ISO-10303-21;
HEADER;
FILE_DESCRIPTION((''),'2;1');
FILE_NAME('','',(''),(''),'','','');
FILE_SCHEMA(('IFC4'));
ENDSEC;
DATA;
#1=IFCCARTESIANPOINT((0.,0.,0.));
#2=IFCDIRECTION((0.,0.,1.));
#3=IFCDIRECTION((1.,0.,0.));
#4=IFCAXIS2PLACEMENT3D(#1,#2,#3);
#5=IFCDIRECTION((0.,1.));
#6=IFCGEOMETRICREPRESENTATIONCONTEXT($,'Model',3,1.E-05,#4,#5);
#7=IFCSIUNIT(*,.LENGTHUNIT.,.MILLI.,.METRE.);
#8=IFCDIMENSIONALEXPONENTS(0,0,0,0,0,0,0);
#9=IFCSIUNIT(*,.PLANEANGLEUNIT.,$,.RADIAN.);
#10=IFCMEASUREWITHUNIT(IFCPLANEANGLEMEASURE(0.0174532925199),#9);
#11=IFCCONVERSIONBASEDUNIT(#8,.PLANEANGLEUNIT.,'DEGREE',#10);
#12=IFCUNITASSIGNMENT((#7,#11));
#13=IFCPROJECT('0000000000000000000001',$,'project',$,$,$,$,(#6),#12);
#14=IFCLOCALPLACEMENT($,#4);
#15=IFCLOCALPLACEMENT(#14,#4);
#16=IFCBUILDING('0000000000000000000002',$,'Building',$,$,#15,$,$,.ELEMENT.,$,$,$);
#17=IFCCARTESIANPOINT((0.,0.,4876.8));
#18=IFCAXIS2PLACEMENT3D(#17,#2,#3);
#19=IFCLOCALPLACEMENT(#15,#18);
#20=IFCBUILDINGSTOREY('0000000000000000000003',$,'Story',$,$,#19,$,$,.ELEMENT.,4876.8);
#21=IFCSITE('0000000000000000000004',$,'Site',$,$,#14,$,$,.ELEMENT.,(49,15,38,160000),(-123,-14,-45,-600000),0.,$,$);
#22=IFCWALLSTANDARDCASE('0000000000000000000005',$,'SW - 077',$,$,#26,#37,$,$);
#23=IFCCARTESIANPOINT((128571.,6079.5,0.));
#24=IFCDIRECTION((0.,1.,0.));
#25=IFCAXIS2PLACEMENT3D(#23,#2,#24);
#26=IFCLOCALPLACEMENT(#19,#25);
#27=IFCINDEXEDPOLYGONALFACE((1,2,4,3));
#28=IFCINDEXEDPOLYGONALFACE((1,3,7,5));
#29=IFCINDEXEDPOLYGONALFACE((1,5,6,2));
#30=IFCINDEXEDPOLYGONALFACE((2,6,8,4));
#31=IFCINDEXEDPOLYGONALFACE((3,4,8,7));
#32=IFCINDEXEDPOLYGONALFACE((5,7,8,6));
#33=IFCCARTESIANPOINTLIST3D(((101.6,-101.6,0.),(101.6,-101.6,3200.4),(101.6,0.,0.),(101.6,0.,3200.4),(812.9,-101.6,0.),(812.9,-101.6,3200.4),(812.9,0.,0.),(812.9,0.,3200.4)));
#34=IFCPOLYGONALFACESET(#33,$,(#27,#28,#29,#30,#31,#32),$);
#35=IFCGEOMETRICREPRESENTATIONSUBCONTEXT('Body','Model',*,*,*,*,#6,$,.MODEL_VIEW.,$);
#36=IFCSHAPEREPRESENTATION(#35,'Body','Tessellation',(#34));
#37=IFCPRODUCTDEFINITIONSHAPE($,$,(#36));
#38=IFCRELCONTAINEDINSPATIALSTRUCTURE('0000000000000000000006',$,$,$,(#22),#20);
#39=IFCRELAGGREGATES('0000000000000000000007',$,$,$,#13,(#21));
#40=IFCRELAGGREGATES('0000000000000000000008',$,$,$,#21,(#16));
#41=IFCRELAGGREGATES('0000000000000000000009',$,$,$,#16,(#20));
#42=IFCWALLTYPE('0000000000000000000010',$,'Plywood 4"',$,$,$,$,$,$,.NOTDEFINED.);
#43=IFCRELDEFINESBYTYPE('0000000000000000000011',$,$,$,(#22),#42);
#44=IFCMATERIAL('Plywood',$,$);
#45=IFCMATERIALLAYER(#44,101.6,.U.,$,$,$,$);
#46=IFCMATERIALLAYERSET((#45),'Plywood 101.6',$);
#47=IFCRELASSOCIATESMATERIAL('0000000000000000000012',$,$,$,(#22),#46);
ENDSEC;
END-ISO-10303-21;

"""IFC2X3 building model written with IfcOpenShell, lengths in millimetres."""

from ifc_helpers import new_model, entity, si_unit, converted_unit, direction, frame, origin_with_axes, place, context, subcontext, project, spatial, polyline, outline, extrude, material, layer, layer_set, layer_usage, type_object, element, save


model = new_model("IFC2X3")

# Units and contexts
model_context = context("Model", 3, precision=1e-05, world=origin_with_axes(), true_north=direction((0.0, 1.0)))
body_context = subcontext(model_context, "Body", "Model", "MODEL_VIEW")
ifc_project = project(units=[si_unit("LENGTHUNIT", "METRE", prefix="MILLI"), converted_unit("PLANEANGLEUNIT", "DEGREE", entity("IfcPlaneAngleMeasure", 0.0174532925199), si_unit("PLANEANGLEUNIT", "RADIAN"), dimensions=[0, 0, 0, 0, 0, 0, 0])], contexts=[model_context])

# Site, building, storey
site_placement = place(None, origin_with_axes())
site = spatial("IfcSite", under=ifc_project, at=site_placement, Name="Site", CompositionType="ELEMENT", RefLatitude=(49, 15, 38, 160000), RefLongitude=(-123, -14, -45, -600000), RefElevation=0.0)
building_placement = place(site_placement, origin_with_axes())
building = spatial("IfcBuilding", under=site, at=building_placement, Name="Building", CompositionType="ELEMENT")
storey_placement = place(building_placement, frame((0.0, 0.0, 4876.8), z_axis=(0.0, 0.0, 1.0), x_axis=(1.0, 0.0, 0.0)))
storey = spatial("IfcBuildingStorey", under=building, at=storey_placement, Name="Story", CompositionType="ELEMENT", Elevation=4876.8)

# Shared definitions
ifc_material_1 = material(Name="Plywood")

# Shared definitions
ifc_layer_1 = layer(ifc_material_1, 101.6, ventilated="UNKNOWN")
ifc_layer_set_1 = layer_set([ifc_layer_1], Name="Plywood 101.6")
wall_type_1 = type_object("IfcWallType", Name="Plywood 4\"", PredefinedType="NOTDEFINED")

# Wall
ifc_layer_usage_1 = layer_usage(ifc_layer_set_1, "AXIS2", "NEGATIVE", 0.0)
wall_1_placement = place(storey_placement, frame((128571.0, 6079.5, 0.0), z_axis=(0.0, 0.0, 1.0), x_axis=(0.0, 1.0, 0.0)))
element("IfcWallStandardCase", 1, at=wall_1_placement, inside=storey, type_object=wall_type_1, material=ifc_layer_usage_1, Name="SW - 077", context=body_context, shape_type="SweptSolid", body=[
    extrude(outline(polyline([(101.6, -101.6), (812.9, -101.6), (812.9, 0.0), (101.6, 0.0), (101.6, -101.6)])), origin_with_axes(), (0.0, 0.0, 1.0), 3200.4),
])

save(model, "model.ifc")
